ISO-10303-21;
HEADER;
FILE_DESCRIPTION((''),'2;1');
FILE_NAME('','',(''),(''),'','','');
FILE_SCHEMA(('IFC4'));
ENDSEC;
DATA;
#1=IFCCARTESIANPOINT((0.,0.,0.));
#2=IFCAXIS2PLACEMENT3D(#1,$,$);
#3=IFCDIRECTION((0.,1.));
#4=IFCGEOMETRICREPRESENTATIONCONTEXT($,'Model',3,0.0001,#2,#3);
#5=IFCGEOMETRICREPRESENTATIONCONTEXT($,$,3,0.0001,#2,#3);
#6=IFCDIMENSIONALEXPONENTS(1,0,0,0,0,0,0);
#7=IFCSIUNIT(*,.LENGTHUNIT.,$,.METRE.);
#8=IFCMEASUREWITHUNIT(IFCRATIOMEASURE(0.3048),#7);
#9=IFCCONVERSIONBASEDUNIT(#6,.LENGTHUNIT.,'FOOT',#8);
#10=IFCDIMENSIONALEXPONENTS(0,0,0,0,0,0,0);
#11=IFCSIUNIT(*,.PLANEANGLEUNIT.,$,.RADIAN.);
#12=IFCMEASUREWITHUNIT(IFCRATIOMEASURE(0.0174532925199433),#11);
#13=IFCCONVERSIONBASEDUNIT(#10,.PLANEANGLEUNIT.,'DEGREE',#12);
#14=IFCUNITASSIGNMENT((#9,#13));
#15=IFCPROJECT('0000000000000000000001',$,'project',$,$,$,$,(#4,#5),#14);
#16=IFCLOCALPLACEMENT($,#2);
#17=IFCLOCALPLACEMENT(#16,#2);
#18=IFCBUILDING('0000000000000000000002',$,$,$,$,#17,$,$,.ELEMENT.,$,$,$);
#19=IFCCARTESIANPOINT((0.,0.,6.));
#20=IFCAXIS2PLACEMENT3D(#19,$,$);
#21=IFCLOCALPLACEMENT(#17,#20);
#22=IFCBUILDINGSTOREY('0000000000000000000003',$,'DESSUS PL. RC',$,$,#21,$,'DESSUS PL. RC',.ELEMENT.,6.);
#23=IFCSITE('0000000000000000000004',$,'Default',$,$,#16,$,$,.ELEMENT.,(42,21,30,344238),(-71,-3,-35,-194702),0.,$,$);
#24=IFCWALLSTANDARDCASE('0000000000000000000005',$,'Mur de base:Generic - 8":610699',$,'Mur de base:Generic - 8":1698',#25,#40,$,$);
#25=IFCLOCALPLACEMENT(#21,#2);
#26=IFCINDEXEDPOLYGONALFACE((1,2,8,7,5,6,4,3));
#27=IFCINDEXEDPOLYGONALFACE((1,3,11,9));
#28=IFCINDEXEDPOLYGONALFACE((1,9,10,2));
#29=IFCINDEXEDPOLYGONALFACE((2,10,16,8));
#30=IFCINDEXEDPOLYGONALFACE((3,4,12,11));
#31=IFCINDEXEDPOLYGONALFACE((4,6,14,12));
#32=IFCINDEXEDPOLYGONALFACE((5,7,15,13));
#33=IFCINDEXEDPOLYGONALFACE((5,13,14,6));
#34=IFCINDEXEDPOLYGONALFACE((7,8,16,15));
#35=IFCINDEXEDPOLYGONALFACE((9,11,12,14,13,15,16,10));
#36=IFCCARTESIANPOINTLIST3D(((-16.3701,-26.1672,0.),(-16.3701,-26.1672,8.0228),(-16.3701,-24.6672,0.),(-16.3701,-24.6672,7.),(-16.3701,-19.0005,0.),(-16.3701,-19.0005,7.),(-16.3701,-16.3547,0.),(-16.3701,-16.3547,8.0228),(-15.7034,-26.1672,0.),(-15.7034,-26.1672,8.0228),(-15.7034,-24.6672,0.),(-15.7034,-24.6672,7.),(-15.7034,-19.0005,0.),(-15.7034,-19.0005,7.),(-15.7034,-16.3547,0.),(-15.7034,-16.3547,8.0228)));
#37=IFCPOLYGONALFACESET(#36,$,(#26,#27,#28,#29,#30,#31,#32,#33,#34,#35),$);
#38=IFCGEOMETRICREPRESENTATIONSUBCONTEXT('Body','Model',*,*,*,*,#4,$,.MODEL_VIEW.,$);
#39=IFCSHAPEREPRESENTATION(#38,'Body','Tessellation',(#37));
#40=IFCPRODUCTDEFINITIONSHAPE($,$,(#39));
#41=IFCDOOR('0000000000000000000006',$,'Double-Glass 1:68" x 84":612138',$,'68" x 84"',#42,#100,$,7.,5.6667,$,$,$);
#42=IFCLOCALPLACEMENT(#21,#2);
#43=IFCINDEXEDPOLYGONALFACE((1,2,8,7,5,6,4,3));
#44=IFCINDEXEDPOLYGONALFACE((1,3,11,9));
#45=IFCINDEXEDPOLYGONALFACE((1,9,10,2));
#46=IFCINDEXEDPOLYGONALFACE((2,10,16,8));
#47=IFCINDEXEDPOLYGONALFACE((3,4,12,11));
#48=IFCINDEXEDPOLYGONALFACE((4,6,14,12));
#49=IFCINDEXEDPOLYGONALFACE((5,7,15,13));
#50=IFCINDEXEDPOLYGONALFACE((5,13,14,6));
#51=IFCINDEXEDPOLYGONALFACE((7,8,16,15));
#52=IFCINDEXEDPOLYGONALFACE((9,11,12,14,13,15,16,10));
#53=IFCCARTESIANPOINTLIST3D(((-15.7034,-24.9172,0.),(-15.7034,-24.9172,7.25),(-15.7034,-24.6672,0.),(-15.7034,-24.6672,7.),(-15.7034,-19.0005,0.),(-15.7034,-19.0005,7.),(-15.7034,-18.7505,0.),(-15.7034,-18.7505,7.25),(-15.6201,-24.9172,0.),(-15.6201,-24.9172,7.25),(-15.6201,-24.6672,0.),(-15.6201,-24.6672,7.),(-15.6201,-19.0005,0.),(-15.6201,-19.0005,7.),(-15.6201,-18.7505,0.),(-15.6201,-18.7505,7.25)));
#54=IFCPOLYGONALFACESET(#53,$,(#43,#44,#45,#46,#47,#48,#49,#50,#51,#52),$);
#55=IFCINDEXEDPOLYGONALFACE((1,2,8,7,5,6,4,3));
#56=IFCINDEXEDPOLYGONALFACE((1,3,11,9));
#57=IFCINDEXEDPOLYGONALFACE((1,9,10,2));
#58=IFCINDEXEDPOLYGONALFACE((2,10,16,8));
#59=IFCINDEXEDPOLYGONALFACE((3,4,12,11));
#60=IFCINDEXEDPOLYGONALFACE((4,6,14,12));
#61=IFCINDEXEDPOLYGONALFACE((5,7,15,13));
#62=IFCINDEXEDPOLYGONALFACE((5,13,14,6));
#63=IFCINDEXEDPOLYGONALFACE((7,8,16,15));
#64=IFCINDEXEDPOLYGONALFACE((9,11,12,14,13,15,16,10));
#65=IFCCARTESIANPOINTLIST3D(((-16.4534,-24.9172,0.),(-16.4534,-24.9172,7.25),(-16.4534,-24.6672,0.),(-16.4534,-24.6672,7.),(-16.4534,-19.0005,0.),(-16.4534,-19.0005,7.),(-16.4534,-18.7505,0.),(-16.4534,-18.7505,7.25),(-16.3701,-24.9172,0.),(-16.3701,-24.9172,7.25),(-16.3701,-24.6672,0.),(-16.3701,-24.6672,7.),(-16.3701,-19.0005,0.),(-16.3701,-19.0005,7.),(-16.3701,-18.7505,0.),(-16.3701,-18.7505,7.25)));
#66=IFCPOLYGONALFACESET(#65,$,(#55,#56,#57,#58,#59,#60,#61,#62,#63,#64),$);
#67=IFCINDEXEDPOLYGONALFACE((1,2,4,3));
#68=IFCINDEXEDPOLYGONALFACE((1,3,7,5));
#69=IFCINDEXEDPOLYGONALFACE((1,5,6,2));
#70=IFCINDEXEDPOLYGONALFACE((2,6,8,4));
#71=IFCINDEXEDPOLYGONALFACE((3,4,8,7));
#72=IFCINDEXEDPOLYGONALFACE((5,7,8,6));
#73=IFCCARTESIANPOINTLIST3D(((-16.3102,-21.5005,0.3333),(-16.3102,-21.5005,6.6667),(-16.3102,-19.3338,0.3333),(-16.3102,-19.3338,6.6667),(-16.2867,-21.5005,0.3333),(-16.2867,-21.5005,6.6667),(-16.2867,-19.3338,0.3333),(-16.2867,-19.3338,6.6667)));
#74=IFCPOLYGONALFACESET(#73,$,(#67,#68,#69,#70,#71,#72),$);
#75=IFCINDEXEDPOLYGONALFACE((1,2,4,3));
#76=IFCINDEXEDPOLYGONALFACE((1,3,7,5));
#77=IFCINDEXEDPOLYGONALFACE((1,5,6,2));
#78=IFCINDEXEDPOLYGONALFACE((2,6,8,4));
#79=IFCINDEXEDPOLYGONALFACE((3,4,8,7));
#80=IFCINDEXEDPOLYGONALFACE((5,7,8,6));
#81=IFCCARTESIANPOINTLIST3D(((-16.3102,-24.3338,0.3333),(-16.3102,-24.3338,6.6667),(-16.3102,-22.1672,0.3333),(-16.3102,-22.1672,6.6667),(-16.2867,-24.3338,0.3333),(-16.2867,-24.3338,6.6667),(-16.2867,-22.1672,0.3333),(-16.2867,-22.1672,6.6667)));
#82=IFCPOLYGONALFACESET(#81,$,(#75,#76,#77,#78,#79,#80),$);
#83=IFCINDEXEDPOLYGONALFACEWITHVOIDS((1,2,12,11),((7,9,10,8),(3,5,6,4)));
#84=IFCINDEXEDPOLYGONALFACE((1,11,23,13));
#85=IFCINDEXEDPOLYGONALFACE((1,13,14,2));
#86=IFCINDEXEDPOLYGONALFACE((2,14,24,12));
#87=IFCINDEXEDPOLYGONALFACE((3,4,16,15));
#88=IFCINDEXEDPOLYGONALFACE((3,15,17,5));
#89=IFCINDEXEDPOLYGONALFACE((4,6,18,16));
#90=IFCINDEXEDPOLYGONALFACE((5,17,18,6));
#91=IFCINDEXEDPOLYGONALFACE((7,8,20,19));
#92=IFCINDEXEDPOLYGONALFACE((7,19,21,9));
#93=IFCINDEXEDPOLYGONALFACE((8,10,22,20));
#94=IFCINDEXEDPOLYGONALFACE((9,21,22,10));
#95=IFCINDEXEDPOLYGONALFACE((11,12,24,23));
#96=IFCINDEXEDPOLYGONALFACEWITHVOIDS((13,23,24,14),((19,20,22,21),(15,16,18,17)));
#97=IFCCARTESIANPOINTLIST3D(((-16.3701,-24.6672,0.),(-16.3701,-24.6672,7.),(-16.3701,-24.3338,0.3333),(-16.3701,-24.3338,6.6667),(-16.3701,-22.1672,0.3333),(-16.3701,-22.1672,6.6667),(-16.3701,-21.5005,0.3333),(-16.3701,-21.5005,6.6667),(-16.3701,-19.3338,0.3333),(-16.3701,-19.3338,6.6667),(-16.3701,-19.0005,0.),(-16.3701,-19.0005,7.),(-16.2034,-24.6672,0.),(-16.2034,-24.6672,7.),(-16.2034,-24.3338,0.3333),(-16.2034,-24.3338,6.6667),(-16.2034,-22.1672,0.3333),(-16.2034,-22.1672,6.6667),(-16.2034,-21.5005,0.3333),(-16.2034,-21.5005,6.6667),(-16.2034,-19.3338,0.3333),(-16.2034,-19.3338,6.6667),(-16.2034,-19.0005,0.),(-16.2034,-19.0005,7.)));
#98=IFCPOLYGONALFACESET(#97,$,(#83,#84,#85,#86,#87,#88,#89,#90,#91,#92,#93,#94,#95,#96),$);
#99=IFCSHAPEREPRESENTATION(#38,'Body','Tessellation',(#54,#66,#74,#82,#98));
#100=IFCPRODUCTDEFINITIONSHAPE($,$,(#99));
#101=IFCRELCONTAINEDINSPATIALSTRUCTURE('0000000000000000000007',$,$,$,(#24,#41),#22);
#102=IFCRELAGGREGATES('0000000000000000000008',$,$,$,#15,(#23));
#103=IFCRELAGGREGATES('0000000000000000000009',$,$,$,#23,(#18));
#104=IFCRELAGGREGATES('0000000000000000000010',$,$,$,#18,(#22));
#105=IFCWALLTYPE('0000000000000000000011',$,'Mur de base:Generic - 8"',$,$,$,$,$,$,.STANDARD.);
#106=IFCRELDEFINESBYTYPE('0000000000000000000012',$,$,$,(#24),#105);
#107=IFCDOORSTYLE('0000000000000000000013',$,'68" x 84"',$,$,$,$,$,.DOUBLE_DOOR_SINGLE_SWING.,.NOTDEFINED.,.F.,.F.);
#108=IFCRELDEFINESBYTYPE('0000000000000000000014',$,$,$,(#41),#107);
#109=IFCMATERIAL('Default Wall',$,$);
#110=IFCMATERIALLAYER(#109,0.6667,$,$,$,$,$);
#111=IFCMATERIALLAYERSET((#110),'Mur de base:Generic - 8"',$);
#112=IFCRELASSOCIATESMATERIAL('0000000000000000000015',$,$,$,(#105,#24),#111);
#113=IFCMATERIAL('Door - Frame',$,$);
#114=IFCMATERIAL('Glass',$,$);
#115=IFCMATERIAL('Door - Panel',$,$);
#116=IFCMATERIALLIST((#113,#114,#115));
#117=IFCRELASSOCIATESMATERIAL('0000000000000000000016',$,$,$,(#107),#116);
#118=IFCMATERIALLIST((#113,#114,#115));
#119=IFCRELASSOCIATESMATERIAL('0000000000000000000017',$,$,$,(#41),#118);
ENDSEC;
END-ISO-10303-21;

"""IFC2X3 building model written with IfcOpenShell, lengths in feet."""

from ifc_helpers import new_model, entity, si_unit, converted_unit, direction, frame, frame_2d, origin, origin_2d_with_axis, place, context, subcontext, project, spatial, polyline, rectangle, outline, extrude, source, transform, mapped, material, material_list, layer, layer_set, layer_usage, type_object, type_shapes, element, fill, save


model = new_model("IFC2X3")

# Units and contexts
model_context = context("Model", 3, precision=0.0001, world=origin(), true_north=direction((0.0, 1.0)))
context_of_model = context(None, 3, precision=0.0001, world=origin(), true_north=direction((0.0, 1.0)))
body_context = subcontext(model_context, "Body", "Model", "MODEL_VIEW")
ifc_project = project(units=[converted_unit("LENGTHUNIT", "FOOT", entity("IfcRatioMeasure", 0.3048), si_unit("LENGTHUNIT", "METRE"), dimensions=[1, 0, 0, 0, 0, 0, 0]), converted_unit("PLANEANGLEUNIT", "DEGREE", entity("IfcRatioMeasure", 0.0174532925199433), si_unit("PLANEANGLEUNIT", "RADIAN"), dimensions=[0, 0, 0, 0, 0, 0, 0])], contexts=[model_context, context_of_model])

# Site, building, storey
site_placement = place(None, origin())
site = spatial("IfcSite", under=ifc_project, at=site_placement, Name="Default", CompositionType="ELEMENT", RefLatitude=(42, 21, 30, 344238), RefLongitude=(-71, -3, -35, -194702), RefElevation=0.0)
building_placement = place(site_placement, origin())
building = spatial("IfcBuilding", under=site, at=building_placement, CompositionType="ELEMENT")
storey_placement = place(building_placement, frame((0.0, 0.0, 6.0)))
storey = spatial("IfcBuildingStorey", under=building, at=storey_placement, Name="DESSUS PL. RC", LongName="DESSUS PL. RC", CompositionType="ELEMENT", Elevation=6.0)

# Shared definitions
ifc_material_1 = material(Name="Default Wall")

# Shared definitions
ifc_material_2 = material(Name="Glass")

# Shared definitions
ifc_material_3 = material(Name="Door - Frame")
ifc_material_4 = material(Name="Door - Panel")

# Shared definitions
ifc_layer_1 = layer(ifc_material_1, 0.6667)
ifc_layer_set_1 = layer_set([ifc_layer_1], Name="Mur de base:Generic - 8\"")
wall_type_1 = type_object("IfcWallType", Name="Mur de base:Generic - 8\"", PredefinedType="STANDARD", material=ifc_layer_set_1)

# Wall, opening, door
ifc_layer_usage_1 = layer_usage(ifc_layer_set_1, "AXIS2", "NEGATIVE", 0.3333)
wall_1_placement = place(storey_placement, frame((-16.0367, -16.3547, 0.0), z_axis=(0.0, 0.0, 1.0), x_axis=(0.0, -1.0, 0.0)))
wall_1 = element("IfcWallStandardCase", 1, at=wall_1_placement, inside=storey, type_object=wall_type_1, material=ifc_layer_usage_1, Name="Mur de base:Generic - 8\":610699", ObjectType="Mur de base:Generic - 8\":1698", context=body_context, shape_type="SweptSolid", body=[
    extrude(rectangle(XDim=9.8125, YDim=0.6667, at=frame_2d((4.9063, 0.0), x_axis=(-1.0, 0.0))), origin(), (0.0, 0.0, 1.0), 8.0228),
])
opening_1_placement = place(wall_1_placement, frame((8.3125, 0.3333, 0.0)))
opening_1 = element("IfcOpeningElement", 2, at=opening_1_placement, cuts=wall_1, ObjectType="Opening", context=body_context, shape_type="SweptSolid", body=[
    extrude(rectangle(XDim=5.6667, YDim=7.0, at=frame_2d((3.5, 2.8333), x_axis=(0.0, 1.0))), frame((0.0, 0.0, 0.0), z_axis=(0.0, -1.0, 0.0), x_axis=(0.0, 0.0, 1.0)), (0.0, 0.0, 1.0), 0.6667),
])
ifc_material_list_1 = material_list([ifc_material_3, ifc_material_2, ifc_material_4])
ifc_material_list_2 = material_list([ifc_material_3, ifc_material_2, ifc_material_4])
door_style_1 = type_object("IfcDoorStyle", Name="68\" x 84\"", ConstructionType="NOTDEFINED", OperationType="DOUBLE_DOOR_SINGLE_SWING", ParameterTakesPrecedence=False, Sizeable=False, material=ifc_material_list_2)
shared_shape_1 = source(origin(), body_context, "Body", "SweptSolid", [
    extrude(outline(polyline([(-3.0833, -3.5625), (-2.8333, -3.5625), (-2.8333, 3.4375), (2.8333, 3.4375), (2.8333, -3.5625), (3.0833, -3.5625), (3.0833, 3.6875), (-3.0833, 3.6875), (-3.0833, -3.5625)])), frame((2.8333, -0.0833, 3.5625), z_axis=(0.0, 1.0, 0.0), x_axis=(-1.0, 0.0, 0.0)), (0.0, 0.0, 1.0), 0.0833),
    extrude(outline(polyline([(-2.8333, -3.4375), (-2.8333, 3.5625), (-3.0833, 3.5625), (-3.0833, -3.6875), (3.0833, -3.6875), (3.0833, 3.5625), (2.8333, 3.5625), (2.8333, -3.4375), (-2.8333, -3.4375)])), frame((2.8333, 0.6667, 3.5625), z_axis=(0.0, -1.0, 0.0), x_axis=(-1.0, 0.0, 0.0)), (0.0, 0.0, -1.0), 0.0833),
    extrude(rectangle(XDim=0.0234, YDim=2.1667, at=frame_2d((0.0, 0.0), x_axis=(1.0, 0.0))), frame((4.25, 0.5951, 0.3333), z_axis=(0.0, 0.0, 1.0), x_axis=(0.0, 1.0, 0.0)), (0.0, 0.0, 1.0), 6.3333),
    extrude(rectangle(XDim=0.0234, YDim=2.1667, at=origin_2d_with_axis()), frame((1.4167, 0.5951, 0.3333), z_axis=(0.0, 0.0, 1.0), x_axis=(0.0, 1.0, 0.0)), (0.0, 0.0, 1.0), 6.3333),
    extrude(outline(polyline([(-3.5, -2.8333), (3.5, -2.8333), (3.5, 2.8333), (-3.5, 2.8333), (-3.5, -2.8333)]), holes=[polyline([(-3.1667, 0.3333), (-3.1667, 2.5), (3.1667, 2.5), (3.1667, 0.3333), (-3.1667, 0.3333)]), polyline([(-3.1667, -2.5), (-3.1667, -0.3333), (3.1667, -0.3333), (3.1667, -2.5), (-3.1667, -2.5)])]), frame((2.8333, 0.5, 3.5), z_axis=(0.0, 1.0, 0.0), x_axis=(0.0, 0.0, -1.0)), (0.0, 0.0, 1.0), 0.1667),
])
type_shapes(door_style_1, [shared_shape_1])
door_1_placement = place(opening_1_placement, frame((0.0, 0.0, 0.0), z_axis=(0.0, 0.0, 1.0), x_axis=(-1.0, 0.0, 0.0)))
door_1 = element("IfcDoor", 3, at=door_1_placement, inside=storey, type_object=door_style_1, material=ifc_material_list_1, Name="Double-Glass 1:68\" x 84\":612138", ObjectType="68\" x 84\"", OverallHeight=7.0, OverallWidth=5.6667, context=body_context, shape_type="MappedRepresentation", body=[
    mapped(shared_shape_1, transform((0.0, 0.0, 0.0), scale=1.0)),
])
fill(opening_1, door_1)

save(model, "model.ifc")
